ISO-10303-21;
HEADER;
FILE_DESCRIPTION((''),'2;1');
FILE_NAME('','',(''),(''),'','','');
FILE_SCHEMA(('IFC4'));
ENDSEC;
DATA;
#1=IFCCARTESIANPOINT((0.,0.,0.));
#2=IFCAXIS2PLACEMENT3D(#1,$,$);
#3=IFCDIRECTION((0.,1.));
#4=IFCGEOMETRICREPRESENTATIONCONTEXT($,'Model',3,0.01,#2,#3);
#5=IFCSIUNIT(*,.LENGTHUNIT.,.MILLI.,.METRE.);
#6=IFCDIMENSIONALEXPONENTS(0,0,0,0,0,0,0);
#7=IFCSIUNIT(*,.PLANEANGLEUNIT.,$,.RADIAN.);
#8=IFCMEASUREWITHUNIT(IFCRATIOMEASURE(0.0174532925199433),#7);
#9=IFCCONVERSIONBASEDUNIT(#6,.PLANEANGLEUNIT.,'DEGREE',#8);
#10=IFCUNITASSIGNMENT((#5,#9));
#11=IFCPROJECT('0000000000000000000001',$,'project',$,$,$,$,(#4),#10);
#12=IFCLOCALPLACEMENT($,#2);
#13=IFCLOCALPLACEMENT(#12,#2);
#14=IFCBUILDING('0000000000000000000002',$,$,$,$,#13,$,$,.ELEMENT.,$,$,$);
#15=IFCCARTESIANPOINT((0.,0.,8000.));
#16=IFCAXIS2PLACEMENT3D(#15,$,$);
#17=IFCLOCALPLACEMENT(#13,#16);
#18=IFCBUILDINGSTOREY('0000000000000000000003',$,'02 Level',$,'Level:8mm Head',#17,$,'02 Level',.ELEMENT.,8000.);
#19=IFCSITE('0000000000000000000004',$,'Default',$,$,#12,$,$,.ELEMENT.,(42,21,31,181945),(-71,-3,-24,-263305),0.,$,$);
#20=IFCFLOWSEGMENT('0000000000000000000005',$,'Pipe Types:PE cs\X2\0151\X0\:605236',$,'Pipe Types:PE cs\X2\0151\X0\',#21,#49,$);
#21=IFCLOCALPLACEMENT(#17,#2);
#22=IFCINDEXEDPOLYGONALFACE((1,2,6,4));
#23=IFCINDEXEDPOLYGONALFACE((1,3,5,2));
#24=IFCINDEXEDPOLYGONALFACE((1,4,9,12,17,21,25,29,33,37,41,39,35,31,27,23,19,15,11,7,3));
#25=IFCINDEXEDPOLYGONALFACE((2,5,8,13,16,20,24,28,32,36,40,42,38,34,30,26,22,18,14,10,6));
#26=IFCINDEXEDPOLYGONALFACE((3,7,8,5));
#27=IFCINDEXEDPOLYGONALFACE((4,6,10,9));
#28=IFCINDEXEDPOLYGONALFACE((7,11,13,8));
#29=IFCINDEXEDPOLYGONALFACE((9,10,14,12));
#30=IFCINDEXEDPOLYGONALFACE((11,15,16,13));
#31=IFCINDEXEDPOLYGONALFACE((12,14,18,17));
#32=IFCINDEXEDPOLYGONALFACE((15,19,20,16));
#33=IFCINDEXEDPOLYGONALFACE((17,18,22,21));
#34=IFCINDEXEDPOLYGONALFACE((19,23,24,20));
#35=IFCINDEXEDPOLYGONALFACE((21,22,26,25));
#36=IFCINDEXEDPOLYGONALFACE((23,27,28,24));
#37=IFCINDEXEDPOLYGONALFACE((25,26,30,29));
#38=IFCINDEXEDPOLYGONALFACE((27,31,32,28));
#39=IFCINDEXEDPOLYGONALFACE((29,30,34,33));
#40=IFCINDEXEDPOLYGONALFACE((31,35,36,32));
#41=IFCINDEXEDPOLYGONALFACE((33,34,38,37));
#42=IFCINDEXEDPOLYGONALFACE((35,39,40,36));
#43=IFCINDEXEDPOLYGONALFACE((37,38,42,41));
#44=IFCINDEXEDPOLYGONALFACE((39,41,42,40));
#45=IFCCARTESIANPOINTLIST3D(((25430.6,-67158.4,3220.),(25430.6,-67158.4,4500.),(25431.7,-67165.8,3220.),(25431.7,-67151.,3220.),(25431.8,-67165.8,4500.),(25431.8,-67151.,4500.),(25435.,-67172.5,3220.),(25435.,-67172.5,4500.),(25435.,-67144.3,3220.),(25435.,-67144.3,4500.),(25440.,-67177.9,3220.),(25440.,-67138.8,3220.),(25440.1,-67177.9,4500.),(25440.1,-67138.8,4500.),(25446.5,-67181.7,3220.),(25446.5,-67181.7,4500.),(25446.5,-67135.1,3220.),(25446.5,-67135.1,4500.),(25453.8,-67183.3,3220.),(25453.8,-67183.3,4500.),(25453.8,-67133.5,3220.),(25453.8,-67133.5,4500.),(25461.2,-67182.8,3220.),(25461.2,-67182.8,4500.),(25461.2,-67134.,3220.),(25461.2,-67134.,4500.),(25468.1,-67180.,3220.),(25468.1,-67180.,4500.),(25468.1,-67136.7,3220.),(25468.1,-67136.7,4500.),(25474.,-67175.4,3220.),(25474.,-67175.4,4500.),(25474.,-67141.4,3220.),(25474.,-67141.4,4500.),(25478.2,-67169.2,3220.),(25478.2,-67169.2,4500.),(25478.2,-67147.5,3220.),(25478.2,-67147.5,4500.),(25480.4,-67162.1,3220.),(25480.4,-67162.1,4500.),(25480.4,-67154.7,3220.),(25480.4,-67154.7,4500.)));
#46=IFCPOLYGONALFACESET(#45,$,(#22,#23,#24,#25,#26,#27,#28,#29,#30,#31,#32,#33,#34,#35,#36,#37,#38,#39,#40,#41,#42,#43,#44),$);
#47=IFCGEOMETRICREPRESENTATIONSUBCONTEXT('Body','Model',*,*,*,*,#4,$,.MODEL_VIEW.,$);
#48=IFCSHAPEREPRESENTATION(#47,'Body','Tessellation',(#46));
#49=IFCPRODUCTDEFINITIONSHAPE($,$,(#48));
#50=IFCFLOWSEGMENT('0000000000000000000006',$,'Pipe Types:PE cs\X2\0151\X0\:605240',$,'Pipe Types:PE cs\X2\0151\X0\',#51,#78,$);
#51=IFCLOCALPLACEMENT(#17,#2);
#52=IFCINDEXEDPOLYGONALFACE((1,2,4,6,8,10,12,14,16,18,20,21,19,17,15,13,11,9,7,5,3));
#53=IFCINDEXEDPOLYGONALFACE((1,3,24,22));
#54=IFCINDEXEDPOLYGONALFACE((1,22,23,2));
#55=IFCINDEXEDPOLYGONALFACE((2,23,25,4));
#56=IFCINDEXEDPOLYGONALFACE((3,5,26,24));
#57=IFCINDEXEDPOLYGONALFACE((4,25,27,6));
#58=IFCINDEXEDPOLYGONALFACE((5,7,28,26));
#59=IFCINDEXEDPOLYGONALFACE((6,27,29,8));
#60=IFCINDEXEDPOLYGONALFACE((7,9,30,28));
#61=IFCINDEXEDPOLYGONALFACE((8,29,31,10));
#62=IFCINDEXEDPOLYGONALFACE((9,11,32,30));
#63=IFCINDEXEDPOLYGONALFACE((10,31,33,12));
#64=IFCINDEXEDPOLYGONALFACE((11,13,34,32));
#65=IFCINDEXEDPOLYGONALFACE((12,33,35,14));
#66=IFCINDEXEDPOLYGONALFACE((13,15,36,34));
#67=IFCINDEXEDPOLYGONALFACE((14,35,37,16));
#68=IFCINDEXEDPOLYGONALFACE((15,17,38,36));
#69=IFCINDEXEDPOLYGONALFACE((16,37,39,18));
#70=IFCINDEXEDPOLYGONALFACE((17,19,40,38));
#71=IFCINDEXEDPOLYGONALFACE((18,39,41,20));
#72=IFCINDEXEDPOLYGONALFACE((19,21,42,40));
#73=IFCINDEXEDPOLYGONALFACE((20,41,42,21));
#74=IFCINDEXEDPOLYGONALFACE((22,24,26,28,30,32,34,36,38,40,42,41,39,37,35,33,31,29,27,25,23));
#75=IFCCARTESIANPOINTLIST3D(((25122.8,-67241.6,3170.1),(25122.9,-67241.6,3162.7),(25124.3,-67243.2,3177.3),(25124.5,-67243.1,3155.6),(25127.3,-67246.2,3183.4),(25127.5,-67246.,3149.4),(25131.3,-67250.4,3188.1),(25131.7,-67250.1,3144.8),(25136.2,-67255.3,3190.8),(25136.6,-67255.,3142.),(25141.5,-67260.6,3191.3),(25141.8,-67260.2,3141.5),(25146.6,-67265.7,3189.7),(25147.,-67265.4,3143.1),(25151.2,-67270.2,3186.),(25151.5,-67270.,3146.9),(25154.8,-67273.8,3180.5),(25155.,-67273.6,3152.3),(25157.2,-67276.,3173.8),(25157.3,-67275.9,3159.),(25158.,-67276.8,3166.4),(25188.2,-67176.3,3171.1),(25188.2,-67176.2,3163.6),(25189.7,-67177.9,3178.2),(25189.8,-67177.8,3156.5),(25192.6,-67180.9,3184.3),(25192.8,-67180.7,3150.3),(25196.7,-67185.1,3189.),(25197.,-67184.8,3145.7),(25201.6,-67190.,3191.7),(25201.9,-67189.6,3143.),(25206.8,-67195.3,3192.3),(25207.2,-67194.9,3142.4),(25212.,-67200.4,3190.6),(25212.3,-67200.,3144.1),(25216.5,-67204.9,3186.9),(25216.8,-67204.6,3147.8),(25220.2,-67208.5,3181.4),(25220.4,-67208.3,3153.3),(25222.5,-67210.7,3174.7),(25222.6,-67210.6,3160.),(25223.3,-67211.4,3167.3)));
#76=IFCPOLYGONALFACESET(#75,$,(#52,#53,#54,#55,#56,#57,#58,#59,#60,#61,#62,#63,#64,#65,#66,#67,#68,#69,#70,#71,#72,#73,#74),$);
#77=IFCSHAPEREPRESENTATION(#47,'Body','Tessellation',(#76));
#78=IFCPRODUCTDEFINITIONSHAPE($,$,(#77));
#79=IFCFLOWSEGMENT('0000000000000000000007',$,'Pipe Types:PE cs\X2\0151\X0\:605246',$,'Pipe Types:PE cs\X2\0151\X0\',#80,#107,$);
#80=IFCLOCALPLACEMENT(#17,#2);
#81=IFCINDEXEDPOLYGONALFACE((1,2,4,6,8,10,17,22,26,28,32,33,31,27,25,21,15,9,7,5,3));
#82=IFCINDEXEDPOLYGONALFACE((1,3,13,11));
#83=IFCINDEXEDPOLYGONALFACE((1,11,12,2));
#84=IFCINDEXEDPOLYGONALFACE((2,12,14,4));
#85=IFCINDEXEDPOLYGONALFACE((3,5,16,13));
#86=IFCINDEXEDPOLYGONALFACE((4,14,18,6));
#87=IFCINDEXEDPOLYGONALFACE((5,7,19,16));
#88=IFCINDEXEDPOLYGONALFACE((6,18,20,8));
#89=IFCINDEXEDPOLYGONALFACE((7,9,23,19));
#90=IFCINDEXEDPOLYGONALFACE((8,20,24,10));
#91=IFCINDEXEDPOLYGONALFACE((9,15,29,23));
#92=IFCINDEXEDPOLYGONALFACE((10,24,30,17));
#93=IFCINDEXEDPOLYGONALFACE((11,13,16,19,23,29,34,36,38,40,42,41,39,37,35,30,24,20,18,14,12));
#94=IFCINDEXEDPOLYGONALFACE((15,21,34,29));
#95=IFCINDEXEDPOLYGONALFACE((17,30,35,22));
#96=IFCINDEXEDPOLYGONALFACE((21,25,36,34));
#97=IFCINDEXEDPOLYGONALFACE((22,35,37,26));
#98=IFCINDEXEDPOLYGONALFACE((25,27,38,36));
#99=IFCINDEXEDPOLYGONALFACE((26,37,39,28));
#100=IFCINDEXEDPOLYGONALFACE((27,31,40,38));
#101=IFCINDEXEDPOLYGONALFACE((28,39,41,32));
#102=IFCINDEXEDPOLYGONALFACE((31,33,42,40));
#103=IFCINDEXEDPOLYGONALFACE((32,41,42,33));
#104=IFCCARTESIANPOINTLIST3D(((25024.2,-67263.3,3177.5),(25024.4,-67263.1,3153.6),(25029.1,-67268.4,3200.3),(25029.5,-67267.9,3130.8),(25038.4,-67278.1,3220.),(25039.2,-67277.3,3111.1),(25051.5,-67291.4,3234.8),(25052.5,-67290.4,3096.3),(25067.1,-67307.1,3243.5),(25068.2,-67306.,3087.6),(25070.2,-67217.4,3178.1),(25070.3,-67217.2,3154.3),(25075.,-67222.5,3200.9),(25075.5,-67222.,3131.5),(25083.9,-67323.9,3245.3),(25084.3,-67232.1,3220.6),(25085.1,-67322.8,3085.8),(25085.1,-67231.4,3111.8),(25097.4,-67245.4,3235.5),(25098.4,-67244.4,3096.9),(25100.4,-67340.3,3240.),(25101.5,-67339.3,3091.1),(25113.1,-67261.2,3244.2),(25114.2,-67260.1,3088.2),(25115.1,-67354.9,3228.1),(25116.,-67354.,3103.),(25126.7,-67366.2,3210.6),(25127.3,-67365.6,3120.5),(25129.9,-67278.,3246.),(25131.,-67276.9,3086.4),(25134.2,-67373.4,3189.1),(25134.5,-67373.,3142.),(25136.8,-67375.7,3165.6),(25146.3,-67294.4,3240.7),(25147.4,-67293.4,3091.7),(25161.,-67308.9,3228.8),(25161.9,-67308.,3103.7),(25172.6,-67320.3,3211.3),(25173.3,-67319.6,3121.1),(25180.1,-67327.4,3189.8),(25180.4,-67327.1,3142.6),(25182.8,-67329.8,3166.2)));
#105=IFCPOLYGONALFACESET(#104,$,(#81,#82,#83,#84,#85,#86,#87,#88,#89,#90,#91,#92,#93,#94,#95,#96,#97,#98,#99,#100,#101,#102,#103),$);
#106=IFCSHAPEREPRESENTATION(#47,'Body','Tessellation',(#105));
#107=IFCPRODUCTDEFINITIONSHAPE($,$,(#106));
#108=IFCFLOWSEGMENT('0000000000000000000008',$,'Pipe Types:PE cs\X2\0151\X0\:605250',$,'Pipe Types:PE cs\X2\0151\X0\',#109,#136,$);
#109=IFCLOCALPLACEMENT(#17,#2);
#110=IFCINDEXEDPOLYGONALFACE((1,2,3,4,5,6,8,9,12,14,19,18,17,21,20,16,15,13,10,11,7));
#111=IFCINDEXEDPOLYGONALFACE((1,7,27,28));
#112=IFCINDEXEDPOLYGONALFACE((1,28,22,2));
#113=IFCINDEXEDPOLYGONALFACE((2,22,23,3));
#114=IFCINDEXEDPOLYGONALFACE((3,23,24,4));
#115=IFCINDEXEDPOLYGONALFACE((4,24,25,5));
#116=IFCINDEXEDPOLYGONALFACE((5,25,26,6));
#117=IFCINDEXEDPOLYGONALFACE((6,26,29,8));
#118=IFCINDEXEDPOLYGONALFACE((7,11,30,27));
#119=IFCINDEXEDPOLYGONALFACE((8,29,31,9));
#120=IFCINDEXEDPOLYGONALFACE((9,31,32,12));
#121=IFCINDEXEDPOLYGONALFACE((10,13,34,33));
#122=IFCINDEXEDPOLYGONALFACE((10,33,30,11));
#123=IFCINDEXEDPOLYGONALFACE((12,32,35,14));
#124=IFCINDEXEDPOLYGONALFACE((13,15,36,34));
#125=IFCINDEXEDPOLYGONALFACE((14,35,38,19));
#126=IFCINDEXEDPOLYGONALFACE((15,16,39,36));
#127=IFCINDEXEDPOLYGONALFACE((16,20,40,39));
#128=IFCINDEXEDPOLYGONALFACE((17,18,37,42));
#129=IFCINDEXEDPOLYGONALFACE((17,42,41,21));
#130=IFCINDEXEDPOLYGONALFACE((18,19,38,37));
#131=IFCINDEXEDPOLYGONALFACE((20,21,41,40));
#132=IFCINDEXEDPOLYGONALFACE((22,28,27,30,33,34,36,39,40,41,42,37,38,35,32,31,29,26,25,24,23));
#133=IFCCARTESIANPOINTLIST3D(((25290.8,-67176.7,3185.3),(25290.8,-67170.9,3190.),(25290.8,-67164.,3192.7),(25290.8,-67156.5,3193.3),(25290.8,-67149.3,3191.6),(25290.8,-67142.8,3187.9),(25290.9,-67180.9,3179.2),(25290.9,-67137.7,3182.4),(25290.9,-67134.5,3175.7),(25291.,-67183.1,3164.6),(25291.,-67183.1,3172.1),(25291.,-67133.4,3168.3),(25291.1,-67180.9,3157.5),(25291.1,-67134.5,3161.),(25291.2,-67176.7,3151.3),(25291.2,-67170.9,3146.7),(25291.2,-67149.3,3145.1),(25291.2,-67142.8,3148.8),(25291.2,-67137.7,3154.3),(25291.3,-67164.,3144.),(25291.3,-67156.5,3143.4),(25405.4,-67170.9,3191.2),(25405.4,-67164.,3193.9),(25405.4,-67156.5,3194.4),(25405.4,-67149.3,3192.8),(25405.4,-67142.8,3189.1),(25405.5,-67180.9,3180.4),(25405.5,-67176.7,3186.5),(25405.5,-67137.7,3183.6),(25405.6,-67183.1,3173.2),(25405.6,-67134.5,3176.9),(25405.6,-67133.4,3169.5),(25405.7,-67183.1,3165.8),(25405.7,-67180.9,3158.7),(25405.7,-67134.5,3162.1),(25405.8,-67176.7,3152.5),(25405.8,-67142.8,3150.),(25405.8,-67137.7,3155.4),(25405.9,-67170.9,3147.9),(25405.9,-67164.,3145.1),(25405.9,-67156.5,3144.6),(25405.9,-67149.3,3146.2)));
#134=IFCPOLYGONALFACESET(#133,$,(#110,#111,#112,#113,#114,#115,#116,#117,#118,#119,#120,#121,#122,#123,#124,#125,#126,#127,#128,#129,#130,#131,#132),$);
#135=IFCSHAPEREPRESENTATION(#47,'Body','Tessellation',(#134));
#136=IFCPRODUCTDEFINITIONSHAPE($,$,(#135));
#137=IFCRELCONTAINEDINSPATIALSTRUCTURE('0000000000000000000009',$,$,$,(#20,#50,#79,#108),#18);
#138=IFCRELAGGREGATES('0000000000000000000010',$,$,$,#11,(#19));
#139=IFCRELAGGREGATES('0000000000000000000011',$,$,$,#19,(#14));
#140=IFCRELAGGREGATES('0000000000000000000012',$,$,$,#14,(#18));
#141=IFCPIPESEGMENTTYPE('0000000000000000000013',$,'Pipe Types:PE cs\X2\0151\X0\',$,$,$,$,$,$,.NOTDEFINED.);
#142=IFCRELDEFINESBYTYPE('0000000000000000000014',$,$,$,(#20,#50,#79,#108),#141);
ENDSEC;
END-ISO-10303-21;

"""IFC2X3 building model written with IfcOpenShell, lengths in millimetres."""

from ifc_helpers import new_model, entity, si_unit, converted_unit, direction, frame, frame_2d, origin, origin_2d_with_axis, place, context, subcontext, project, spatial, circle, extrude, type_object, element, save


model = new_model("IFC2X3")

# Units and contexts
model_context = context("Model", 3, precision=0.01, world=origin(), true_north=direction((0.0, 1.0)))
body_context = subcontext(model_context, "Body", "Model", "MODEL_VIEW")
ifc_project = project(units=[si_unit("LENGTHUNIT", "METRE", prefix="MILLI"), converted_unit("PLANEANGLEUNIT", "DEGREE", entity("IfcRatioMeasure", 0.0174532925199433), si_unit("PLANEANGLEUNIT", "RADIAN"), dimensions=[0, 0, 0, 0, 0, 0, 0])], contexts=[model_context])

# Site, building, storey
site_placement = place(None, origin())
site = spatial("IfcSite", under=ifc_project, at=site_placement, Name="Default", CompositionType="ELEMENT", RefLatitude=(42, 21, 31, 181945), RefLongitude=(-71, -3, -24, -263305), RefElevation=0.0)
building_placement = place(site_placement, origin())
building = spatial("IfcBuilding", under=site, at=building_placement, CompositionType="ELEMENT")
storey_placement = place(building_placement, frame((0.0, 0.0, 8000.0)))
storey = spatial("IfcBuildingStorey", under=building, at=storey_placement, Name="02 Level", ObjectType="Level:8mm Head", LongName="02 Level", CompositionType="ELEMENT", Elevation=8000.0)

# Flow segments
pipe_segment_type = type_object("IfcPipeSegmentType", Name="Pipe Types:PE cső", PredefinedType="NOTDEFINED")
flow_segment_1_placement = place(storey_placement, frame((25429.0, -67185.0, 3220.0)))
element("IfcFlowSegment", 1, at=flow_segment_1_placement, inside=storey, type_object=pipe_segment_type, Name="Pipe Types:PE cső:605236", ObjectType="Pipe Types:PE cső", context=body_context, shape_type="SweptSolid", body=[
    extrude(circle(Radius=25.0, at=frame_2d((0.0, 0.0), x_axis=(1.0, 0.0))), frame((26.6, 26.6, 0.0), z_axis=(0.000007, 0.000001, 1.0), x_axis=(-1.0, 0.0, 0.000007)), (0.0, 0.0, 1.0), 1280.0),
])
flow_segment_2_placement = place(storey_placement, frame((25121.1, -67278.4, 3139.8)))
element("IfcFlowSegment", 2, at=flow_segment_2_placement, inside=storey, type_object=pipe_segment_type, Name="Pipe Types:PE cső:605240", ObjectType="Pipe Types:PE cső", context=body_context, shape_type="SweptSolid", body=[
    extrude(circle(Radius=25.0, at=origin_2d_with_axis()), frame((19.3, 19.3, 26.6), z_axis=(0.707072, 0.707071, 0.009982), x_axis=(0.707107, -0.707107, 0.0)), (0.0, 0.0, 1.0), 92.4),
])
flow_segment_3_placement = place(storey_placement, frame((25022.1, -67377.3, 3084.0)))
element("IfcFlowSegment", 3, at=flow_segment_3_placement, inside=storey, type_object=pipe_segment_type, Name="Pipe Types:PE cső:605246", ObjectType="Pipe Types:PE cső", context=body_context, shape_type="SweptSolid", body=[
    extrude(circle(Radius=80.0, at=origin_2d_with_axis()), frame((58.2, 58.2, 81.6), z_axis=(0.707071, 0.707071, 0.010046), x_axis=(0.707107, -0.707107, 0.0)), (0.0, 0.0, 1.0), 65.0),
])
flow_segment_4_placement = place(storey_placement, frame((25289.2, -67185.0, 3141.7)))
element("IfcFlowSegment", 4, at=flow_segment_4_placement, inside=storey, type_object=pipe_segment_type, Name="Pipe Types:PE cső:605250", ObjectType="Pipe Types:PE cső", context=body_context, shape_type="SweptSolid", body=[
    extrude(circle(Radius=25.0, at=origin_2d_with_axis()), frame((1.9, 26.6, 26.6), z_axis=(0.999948, 0.000032, 0.010203), x_axis=(-0.000032, 1.0, 0.0)), (0.0, 0.0, 1.0), 114.6),
])

save(model, "model.ifc")
